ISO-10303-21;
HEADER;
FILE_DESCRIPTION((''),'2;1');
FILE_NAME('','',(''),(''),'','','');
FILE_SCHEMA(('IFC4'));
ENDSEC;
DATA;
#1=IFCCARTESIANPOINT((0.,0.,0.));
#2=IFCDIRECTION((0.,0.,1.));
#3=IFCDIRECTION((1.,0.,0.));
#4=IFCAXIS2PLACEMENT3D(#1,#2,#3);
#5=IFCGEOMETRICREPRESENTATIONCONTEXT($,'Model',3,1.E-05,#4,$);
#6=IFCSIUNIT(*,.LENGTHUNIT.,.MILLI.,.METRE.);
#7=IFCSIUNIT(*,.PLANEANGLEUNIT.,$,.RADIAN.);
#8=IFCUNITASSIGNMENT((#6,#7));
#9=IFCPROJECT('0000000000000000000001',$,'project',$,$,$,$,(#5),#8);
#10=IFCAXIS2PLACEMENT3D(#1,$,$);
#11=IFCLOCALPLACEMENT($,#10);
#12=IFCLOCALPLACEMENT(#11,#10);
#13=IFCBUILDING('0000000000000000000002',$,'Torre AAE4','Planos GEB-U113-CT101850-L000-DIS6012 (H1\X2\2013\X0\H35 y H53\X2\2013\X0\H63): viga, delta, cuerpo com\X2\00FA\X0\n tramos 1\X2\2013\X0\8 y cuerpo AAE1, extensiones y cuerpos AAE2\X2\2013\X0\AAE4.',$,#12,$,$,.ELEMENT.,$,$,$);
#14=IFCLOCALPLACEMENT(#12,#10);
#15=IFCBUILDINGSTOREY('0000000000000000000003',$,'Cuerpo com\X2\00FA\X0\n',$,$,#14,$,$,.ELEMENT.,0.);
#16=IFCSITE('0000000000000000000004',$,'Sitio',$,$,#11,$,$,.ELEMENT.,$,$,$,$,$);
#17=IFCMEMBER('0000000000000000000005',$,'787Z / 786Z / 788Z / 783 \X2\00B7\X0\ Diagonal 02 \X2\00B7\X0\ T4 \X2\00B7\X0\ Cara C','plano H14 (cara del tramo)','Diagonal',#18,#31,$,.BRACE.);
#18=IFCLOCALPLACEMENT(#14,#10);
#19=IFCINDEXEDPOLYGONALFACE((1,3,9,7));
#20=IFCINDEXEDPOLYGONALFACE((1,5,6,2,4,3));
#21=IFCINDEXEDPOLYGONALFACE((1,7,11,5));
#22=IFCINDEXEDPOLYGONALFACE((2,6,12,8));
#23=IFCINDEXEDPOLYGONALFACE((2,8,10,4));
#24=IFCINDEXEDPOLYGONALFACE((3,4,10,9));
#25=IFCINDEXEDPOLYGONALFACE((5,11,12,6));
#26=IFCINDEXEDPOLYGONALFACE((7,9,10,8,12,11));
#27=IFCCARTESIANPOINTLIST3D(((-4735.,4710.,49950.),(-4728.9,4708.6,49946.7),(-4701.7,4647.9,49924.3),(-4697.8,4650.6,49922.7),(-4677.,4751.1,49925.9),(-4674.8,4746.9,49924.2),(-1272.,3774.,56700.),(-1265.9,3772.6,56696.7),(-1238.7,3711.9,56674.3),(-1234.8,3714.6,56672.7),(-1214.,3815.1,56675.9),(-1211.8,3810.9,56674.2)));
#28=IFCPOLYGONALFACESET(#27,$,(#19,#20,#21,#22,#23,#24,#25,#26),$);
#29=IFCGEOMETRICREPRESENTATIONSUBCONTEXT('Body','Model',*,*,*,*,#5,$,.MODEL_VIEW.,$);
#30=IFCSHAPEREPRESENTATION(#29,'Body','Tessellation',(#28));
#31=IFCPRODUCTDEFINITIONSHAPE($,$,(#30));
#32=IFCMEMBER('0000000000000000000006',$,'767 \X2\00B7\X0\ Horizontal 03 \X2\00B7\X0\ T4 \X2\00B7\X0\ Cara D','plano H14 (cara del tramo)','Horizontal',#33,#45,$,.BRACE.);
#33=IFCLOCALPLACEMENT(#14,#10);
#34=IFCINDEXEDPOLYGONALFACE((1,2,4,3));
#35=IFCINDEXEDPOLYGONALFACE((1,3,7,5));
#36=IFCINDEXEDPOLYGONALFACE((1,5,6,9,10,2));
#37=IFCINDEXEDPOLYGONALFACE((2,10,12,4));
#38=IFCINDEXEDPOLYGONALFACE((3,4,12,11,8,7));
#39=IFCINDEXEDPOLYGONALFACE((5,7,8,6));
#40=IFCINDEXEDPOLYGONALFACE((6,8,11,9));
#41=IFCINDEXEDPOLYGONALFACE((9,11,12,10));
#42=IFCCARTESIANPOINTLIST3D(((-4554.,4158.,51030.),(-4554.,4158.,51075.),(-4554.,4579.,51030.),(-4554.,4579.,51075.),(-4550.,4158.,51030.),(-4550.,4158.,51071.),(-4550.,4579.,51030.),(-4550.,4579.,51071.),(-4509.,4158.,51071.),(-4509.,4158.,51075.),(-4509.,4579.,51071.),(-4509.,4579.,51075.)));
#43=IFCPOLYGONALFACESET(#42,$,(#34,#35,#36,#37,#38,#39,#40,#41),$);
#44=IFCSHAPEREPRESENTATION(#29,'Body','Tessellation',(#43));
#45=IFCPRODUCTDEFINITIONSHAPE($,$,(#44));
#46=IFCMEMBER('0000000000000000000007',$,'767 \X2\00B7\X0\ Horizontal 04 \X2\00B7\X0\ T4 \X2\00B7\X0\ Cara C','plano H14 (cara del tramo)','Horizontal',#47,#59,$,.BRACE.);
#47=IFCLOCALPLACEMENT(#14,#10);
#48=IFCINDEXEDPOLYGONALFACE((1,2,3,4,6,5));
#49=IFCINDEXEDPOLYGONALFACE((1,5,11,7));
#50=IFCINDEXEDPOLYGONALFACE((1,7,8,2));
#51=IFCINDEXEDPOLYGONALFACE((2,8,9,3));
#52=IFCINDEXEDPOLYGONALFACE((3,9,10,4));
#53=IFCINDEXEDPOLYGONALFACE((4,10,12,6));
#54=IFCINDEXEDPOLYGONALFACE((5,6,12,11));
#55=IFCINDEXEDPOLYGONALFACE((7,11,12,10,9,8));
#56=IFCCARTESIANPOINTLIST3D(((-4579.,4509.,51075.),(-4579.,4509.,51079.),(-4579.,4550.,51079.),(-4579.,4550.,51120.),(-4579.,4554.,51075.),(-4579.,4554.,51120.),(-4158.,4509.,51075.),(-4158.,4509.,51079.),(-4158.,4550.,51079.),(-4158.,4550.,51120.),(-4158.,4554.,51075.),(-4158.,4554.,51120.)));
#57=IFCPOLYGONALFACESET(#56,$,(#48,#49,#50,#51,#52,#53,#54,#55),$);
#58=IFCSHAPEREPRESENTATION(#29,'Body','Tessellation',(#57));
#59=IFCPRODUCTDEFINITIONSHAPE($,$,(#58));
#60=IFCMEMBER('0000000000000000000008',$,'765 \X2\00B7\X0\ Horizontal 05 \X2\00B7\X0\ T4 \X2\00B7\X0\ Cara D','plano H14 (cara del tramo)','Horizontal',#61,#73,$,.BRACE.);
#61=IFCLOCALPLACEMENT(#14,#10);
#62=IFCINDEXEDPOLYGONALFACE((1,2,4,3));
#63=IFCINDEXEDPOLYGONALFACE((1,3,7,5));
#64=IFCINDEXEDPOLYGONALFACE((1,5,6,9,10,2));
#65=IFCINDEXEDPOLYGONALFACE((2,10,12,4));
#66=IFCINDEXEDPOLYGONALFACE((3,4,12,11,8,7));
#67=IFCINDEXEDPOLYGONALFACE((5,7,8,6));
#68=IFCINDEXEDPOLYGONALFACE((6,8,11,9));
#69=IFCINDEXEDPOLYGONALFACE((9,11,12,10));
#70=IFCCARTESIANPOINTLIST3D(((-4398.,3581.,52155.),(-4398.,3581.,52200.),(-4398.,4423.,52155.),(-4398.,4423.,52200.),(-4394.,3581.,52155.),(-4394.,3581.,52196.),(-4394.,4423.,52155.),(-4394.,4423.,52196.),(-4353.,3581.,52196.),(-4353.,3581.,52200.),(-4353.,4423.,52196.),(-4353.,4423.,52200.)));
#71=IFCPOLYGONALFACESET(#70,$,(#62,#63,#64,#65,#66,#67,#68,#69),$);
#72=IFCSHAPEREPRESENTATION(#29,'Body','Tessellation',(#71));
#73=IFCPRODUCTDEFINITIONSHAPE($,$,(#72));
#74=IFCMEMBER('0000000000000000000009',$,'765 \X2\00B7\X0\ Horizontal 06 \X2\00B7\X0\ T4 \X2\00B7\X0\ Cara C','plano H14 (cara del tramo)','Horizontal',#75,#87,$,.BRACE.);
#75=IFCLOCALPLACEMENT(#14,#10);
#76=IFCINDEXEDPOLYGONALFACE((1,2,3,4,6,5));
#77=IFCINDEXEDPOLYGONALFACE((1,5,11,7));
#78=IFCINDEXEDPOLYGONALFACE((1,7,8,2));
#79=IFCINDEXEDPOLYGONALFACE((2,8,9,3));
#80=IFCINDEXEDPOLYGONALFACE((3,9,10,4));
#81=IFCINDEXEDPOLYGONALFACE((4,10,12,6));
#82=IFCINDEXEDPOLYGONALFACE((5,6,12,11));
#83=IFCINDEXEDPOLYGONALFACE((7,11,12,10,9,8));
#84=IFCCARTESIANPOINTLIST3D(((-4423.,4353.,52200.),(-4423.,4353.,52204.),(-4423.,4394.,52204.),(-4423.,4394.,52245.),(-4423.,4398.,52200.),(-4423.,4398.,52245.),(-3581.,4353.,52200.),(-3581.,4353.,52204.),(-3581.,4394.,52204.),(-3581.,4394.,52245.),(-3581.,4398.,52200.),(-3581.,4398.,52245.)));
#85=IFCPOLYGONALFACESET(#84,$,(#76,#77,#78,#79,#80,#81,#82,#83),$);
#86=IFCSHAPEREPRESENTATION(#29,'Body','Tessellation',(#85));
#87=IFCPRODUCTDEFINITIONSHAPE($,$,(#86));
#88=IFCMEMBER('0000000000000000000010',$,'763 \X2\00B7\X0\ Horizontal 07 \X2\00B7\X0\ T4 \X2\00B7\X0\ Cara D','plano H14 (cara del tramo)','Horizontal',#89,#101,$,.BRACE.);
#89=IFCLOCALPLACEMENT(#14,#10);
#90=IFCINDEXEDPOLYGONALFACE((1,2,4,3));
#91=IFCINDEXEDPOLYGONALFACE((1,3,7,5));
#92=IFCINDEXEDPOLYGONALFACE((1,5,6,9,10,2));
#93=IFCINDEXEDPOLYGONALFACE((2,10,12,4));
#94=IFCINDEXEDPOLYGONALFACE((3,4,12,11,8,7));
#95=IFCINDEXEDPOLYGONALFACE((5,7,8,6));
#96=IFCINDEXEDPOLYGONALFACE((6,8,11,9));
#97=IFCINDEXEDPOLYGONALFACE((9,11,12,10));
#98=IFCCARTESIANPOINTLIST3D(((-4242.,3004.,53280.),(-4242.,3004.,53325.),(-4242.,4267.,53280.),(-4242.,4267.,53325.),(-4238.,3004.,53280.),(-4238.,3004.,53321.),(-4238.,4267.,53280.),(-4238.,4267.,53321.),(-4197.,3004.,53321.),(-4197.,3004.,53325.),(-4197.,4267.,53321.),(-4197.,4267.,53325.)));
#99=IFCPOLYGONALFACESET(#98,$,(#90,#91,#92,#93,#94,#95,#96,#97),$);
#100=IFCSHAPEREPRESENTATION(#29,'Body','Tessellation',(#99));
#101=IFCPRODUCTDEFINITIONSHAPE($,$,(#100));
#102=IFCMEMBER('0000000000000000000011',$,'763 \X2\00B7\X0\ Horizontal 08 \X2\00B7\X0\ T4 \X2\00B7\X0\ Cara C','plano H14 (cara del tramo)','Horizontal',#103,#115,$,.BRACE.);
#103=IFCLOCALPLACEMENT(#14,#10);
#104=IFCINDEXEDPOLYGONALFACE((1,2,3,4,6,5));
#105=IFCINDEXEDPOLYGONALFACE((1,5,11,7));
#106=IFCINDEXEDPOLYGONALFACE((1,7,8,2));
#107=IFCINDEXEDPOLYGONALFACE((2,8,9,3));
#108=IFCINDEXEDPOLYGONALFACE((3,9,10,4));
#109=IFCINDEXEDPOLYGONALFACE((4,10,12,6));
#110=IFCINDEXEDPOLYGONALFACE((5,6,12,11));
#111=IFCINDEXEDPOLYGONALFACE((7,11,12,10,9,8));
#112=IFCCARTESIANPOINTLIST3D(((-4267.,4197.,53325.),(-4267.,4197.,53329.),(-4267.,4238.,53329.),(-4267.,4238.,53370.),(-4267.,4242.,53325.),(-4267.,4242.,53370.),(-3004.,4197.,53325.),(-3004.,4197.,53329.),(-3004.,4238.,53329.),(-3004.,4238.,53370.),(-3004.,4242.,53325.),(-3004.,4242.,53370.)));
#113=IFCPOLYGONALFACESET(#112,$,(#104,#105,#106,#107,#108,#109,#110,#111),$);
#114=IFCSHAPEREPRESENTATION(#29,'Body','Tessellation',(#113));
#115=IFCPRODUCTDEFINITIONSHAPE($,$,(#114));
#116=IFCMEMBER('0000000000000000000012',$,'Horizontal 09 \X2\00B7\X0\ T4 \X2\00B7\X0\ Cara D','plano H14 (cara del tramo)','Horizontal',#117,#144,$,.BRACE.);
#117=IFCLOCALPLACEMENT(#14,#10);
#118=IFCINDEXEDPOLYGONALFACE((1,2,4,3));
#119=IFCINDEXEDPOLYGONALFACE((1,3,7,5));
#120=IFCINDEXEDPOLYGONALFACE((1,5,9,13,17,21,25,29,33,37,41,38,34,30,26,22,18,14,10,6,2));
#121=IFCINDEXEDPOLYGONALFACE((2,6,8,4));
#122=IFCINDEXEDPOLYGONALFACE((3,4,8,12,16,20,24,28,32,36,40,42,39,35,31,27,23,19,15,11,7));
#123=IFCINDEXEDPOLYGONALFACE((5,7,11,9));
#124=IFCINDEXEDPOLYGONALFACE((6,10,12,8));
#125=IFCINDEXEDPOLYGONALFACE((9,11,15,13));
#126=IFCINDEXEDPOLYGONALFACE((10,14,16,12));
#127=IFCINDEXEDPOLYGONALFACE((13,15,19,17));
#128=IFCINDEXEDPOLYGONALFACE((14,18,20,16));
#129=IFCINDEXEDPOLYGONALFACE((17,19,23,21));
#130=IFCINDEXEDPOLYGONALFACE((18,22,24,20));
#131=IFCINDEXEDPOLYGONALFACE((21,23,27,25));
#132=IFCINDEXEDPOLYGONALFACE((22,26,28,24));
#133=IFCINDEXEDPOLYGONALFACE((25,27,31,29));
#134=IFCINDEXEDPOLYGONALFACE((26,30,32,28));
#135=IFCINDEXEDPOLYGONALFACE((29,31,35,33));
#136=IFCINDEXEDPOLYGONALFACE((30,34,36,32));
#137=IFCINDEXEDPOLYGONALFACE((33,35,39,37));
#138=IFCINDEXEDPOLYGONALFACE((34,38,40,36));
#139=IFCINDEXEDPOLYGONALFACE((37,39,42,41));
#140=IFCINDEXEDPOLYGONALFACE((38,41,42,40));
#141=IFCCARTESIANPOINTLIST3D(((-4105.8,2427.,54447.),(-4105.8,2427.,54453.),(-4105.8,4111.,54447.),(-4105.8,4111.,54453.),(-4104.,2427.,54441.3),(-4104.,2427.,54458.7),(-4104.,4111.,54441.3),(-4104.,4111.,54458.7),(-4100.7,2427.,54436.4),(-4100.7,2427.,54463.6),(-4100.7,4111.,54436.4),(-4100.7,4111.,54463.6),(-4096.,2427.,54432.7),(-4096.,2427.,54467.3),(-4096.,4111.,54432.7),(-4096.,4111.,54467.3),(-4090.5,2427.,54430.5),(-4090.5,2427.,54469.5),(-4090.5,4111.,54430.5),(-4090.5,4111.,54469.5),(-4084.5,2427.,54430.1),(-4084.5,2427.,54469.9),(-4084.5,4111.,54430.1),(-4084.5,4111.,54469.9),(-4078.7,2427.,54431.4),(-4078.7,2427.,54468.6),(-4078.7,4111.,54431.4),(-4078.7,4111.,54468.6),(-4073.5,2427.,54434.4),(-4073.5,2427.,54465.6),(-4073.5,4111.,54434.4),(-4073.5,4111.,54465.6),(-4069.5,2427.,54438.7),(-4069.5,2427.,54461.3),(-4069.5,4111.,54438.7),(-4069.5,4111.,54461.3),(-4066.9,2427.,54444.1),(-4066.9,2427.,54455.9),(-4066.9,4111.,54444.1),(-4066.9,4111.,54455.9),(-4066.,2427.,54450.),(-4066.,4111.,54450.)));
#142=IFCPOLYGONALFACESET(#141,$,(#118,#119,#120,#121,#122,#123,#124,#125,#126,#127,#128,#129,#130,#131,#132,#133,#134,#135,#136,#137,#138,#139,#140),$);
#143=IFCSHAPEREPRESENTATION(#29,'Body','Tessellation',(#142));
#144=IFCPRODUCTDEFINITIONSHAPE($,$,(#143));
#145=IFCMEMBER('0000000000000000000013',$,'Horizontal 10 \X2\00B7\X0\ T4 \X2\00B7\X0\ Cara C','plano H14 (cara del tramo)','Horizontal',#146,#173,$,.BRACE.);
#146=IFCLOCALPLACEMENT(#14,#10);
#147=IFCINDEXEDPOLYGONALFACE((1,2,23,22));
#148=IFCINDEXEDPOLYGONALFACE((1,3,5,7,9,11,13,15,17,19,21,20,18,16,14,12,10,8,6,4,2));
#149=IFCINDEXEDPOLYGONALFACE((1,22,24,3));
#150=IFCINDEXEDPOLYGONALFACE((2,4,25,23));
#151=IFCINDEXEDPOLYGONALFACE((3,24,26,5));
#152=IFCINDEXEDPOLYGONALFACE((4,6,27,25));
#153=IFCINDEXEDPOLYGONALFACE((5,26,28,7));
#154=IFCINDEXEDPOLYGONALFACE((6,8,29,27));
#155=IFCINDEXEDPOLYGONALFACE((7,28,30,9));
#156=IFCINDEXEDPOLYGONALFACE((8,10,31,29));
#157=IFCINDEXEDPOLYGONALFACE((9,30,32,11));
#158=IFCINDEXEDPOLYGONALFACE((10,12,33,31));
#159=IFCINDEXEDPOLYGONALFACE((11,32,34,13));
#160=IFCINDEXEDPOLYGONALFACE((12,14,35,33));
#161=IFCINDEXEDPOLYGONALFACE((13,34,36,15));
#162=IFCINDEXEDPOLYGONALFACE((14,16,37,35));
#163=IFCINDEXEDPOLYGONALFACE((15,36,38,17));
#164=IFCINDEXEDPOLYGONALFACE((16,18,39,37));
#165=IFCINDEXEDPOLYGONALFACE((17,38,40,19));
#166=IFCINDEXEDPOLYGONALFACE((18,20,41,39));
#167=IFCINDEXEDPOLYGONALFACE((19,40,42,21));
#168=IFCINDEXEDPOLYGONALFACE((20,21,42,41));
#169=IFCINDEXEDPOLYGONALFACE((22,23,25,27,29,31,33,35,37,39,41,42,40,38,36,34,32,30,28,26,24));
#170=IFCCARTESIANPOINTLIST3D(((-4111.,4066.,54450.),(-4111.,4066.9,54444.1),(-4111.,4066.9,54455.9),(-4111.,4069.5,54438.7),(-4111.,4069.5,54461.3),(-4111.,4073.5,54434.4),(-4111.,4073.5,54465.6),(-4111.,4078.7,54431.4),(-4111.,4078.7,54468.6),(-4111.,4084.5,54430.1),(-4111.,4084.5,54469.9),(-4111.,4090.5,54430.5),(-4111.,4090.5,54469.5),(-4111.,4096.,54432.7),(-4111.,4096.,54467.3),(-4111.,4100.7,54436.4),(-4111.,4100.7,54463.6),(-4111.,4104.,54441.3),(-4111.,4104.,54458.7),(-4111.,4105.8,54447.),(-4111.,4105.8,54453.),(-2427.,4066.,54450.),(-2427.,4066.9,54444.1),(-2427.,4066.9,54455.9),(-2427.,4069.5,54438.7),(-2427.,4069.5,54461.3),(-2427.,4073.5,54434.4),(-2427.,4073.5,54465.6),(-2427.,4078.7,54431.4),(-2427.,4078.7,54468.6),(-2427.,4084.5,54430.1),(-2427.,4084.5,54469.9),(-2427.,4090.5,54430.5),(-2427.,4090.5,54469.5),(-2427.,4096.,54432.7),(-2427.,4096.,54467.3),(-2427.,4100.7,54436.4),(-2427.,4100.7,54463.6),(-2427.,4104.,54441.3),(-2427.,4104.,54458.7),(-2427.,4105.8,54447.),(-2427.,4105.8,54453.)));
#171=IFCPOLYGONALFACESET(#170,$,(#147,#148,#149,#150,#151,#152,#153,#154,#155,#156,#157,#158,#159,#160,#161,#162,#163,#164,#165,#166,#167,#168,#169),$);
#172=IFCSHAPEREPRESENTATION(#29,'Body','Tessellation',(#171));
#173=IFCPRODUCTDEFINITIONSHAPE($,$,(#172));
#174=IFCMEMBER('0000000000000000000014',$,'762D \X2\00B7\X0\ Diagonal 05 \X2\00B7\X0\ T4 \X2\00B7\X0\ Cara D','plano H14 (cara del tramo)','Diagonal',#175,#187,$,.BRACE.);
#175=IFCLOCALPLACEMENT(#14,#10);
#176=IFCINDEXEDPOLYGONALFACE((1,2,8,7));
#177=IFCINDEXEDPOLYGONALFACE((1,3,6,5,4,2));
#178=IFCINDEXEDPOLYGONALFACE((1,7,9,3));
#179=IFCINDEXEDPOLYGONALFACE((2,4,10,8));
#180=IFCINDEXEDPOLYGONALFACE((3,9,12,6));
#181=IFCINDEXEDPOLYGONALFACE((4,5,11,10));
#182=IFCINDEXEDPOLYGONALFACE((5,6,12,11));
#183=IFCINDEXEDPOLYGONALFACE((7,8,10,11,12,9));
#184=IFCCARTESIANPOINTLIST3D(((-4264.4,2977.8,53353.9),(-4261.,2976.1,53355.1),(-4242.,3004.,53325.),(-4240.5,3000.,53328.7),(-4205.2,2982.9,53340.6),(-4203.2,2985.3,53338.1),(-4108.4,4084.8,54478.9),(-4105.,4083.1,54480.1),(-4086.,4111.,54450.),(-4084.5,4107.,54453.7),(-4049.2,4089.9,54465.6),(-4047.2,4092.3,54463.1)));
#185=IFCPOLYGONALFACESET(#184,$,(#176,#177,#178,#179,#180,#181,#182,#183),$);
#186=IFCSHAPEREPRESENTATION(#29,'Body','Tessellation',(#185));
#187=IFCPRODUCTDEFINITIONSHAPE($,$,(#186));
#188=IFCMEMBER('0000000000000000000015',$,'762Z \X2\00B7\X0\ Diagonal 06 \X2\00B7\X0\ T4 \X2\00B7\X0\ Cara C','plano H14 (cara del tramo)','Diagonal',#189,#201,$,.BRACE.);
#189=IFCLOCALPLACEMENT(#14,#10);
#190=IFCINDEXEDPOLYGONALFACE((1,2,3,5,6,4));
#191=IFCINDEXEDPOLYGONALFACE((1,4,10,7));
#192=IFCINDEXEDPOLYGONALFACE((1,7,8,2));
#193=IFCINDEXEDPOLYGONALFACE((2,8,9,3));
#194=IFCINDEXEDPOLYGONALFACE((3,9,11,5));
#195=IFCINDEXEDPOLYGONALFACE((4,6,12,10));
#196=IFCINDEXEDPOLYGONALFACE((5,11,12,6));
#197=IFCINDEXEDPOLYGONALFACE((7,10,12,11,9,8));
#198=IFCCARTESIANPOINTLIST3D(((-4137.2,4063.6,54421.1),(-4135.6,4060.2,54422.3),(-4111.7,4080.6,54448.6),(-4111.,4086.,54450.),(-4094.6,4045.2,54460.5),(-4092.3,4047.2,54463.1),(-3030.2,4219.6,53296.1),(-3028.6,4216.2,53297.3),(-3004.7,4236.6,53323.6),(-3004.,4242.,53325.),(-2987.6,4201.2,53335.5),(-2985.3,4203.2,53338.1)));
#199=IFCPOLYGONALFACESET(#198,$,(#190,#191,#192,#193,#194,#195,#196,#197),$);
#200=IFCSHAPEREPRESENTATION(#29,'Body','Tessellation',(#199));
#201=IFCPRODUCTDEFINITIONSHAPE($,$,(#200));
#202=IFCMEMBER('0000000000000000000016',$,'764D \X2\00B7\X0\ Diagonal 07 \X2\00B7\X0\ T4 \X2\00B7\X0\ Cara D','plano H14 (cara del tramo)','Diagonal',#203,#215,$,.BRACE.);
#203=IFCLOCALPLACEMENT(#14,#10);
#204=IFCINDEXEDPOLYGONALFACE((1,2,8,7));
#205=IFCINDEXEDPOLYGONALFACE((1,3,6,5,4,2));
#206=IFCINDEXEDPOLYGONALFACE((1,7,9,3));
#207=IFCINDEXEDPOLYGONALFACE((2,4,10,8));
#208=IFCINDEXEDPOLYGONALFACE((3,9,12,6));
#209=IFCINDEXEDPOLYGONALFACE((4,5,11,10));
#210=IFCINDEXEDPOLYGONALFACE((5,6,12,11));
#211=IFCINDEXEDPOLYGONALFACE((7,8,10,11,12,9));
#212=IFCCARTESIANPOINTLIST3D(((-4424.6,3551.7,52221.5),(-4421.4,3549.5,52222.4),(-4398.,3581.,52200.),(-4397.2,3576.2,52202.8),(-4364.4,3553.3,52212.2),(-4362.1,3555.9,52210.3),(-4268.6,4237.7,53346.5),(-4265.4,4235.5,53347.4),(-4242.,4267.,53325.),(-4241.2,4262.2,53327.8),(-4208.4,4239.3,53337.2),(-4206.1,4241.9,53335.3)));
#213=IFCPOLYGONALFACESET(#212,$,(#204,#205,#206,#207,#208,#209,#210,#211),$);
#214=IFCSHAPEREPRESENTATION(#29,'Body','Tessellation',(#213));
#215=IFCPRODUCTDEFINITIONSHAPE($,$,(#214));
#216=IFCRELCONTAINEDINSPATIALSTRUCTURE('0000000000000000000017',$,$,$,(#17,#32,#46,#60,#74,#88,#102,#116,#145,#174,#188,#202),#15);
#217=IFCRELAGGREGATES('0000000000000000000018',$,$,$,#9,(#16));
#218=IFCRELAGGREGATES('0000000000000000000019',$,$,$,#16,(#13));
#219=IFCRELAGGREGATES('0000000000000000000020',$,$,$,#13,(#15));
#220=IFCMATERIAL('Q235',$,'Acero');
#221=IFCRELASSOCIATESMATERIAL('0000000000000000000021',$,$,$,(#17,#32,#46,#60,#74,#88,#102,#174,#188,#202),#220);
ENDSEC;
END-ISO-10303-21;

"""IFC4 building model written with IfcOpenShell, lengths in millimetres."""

from ifc_helpers import new_model, si_unit, frame, frame_2d, origin, origin_with_axes, place, context, subcontext, project, spatial, circle, l_section, extrude, material, element, save


model = new_model("IFC4")

# Units and contexts
model_context = context("Model", 3, precision=1e-05, world=origin_with_axes())
body_context = subcontext(model_context, "Body", "Model", "MODEL_VIEW")
ifc_project = project(units=[si_unit("LENGTHUNIT", "METRE", prefix="MILLI"), si_unit("PLANEANGLEUNIT", "RADIAN")], contexts=[model_context])

# Site, building, storey
site_placement = place(None, origin())
site = spatial("IfcSite", under=ifc_project, at=site_placement, Name="Sitio", CompositionType="ELEMENT")
building_placement = place(site_placement, origin())
building = spatial("IfcBuilding", under=site, at=building_placement, Name="Torre AAE4", Description="Planos GEB-U113-CT101850-L000-DIS6012 (H1–H35 y H53–H63): viga, delta, cuerpo común tramos 1–8 y cuerpo AAE1, extensiones y cuerpos AAE2–AAE4.", CompositionType="ELEMENT")
storey_placement = place(building_placement, origin())
storey = spatial("IfcBuildingStorey", under=building, at=storey_placement, Name="Cuerpo común", CompositionType="ELEMENT", Elevation=0.0)

# Members
ifc_material_1 = material(Name="Q235", Category="Acero")
member_1_placement = place(storey_placement, frame((-4735.0, 4710.0, 49950.0), z_axis=(0.453034, -0.122449, 0.883044), x_axis=(0.444053, -0.827907, -0.342619)))
element("IfcMember", 1, at=member_1_placement, inside=storey, material=ifc_material_1, Name="787Z / 786Z / 788Z / 783 · Diagonal 02 · T4 · Cara C", Description="plano H14 (cara del tramo)", ObjectType="Diagonal", PredefinedType="BRACE", context=body_context, shape_type="SweptSolid", body=[
    extrude(l_section(Depth=75.0, Width=75.0, Thickness=5.0, at=frame_2d((37.5, 37.5))), None, (0.0, 0.0, 1.0), 7644.0),
])
for number, where, z_axis, x_axis, name in (
    (2, (-4554.0, 4158.0, 51075.0), (0.0, 1.0, 0.0), (1.0, 0.0, 0.0), "767 · Horizontal 03 · T4 · Cara D"),
    (3, (-4158.0, 4554.0, 51075.0), (-1.0, 0.0, 0.0), (0.0, -1.0, 0.0), "767 · Horizontal 04 · T4 · Cara C"),
):
    element("IfcMember", number, at=place(storey_placement, frame(where, z_axis=z_axis, x_axis=x_axis)), inside=storey, material=ifc_material_1, Name=name, Description="plano H14 (cara del tramo)", ObjectType="Horizontal", PredefinedType="BRACE", context=body_context, shape_type="SweptSolid", body=[
        extrude(l_section(Depth=45.0, Width=45.0, Thickness=4.0, at=frame_2d((22.5, 22.5))), None, (0.0, 0.0, 1.0), 421.0),
    ])
for number, where, z_axis, x_axis, name in (
    (4, (-4398.0, 3581.0, 52200.0), (0.0, 1.0, 0.0), (1.0, 0.0, 0.0), "765 · Horizontal 05 · T4 · Cara D"),
    (5, (-3581.0, 4398.0, 52200.0), (-1.0, 0.0, 0.0), (0.0, -1.0, 0.0), "765 · Horizontal 06 · T4 · Cara C"),
):
    element("IfcMember", number, at=place(storey_placement, frame(where, z_axis=z_axis, x_axis=x_axis)), inside=storey, material=ifc_material_1, Name=name, Description="plano H14 (cara del tramo)", ObjectType="Horizontal", PredefinedType="BRACE", context=body_context, shape_type="SweptSolid", body=[
        extrude(l_section(Depth=45.0, Width=45.0, Thickness=4.0, at=frame_2d((22.5, 22.5))), None, (0.0, 0.0, 1.0), 842.0),
    ])
for number, where, z_axis, x_axis, name in (
    (6, (-4242.0, 3004.0, 53325.0), (0.0, 1.0, 0.0), (1.0, 0.0, 0.0), "763 · Horizontal 07 · T4 · Cara D"),
    (7, (-3004.0, 4242.0, 53325.0), (-1.0, 0.0, 0.0), (0.0, -1.0, 0.0), "763 · Horizontal 08 · T4 · Cara C"),
):
    element("IfcMember", number, at=place(storey_placement, frame(where, z_axis=z_axis, x_axis=x_axis)), inside=storey, material=ifc_material_1, Name=name, Description="plano H14 (cara del tramo)", ObjectType="Horizontal", PredefinedType="BRACE", context=body_context, shape_type="SweptSolid", body=[
        extrude(l_section(Depth=45.0, Width=45.0, Thickness=4.0, at=frame_2d((22.5, 22.5))), None, (0.0, 0.0, 1.0), 1263.0),
    ])
for number, where, z_axis, x_axis, name in (
    (8, (-4086.0, 2427.0, 54450.0), (0.0, 1.0, 0.0), (1.0, 0.0, 0.0), "Horizontal 09 · T4 · Cara D"),
    (9, (-2427.0, 4086.0, 54450.0), (-1.0, 0.0, 0.0), (0.0, -1.0, 0.0), "Horizontal 10 · T4 · Cara C"),
):
    element("IfcMember", number, at=place(storey_placement, frame(where, z_axis=z_axis, x_axis=x_axis)), inside=storey, Name=name, Description="plano H14 (cara del tramo)", ObjectType="Horizontal", PredefinedType="BRACE", context=body_context, shape_type="SweptSolid", body=[
        extrude(circle(Radius=20.0), None, (0.0, 0.0, 1.0), 1684.0),
    ])
for number, where, z_axis, x_axis, name in (
    (10, (-4086.0, 4111.0, 54450.0), (-0.09836, -0.69798, -0.70933), (0.861689, -0.416299, 0.290151), "762D · Diagonal 05 · T4 · Cara D"),
    (11, (-4111.0, 4086.0, 54450.0), (0.69798, 0.09836, -0.70933), (0.416299, -0.861689, 0.290151), "762Z · Diagonal 06 · T4 · Cara C"),
):
    element("IfcMember", number, at=place(storey_placement, frame(where, z_axis=z_axis, x_axis=x_axis)), inside=storey, material=ifc_material_1, Name=name, Description="plano H14 (cara del tramo)", ObjectType="Diagonal", PredefinedType="BRACE", context=body_context, shape_type="SweptSolid", body=[
        extrude(l_section(Depth=45.0, Width=45.0, Thickness=4.0, at=frame_2d((22.5, 22.5))), None, (0.0, 0.0, 1.0), 1586.0),
    ])
for number, where, z_axis, x_axis, name in (
    (12, (-4242.0, 4267.0, 53325.0), (-0.117571, -0.51701, -0.847867), (0.798444, -0.556878, 0.228854), "764D · Diagonal 07 · T4 · Cara D"),
):
    element("IfcMember", number, at=place(storey_placement, frame(where, z_axis=z_axis, x_axis=x_axis)), inside=storey, material=ifc_material_1, Name=name, Description="plano H14 (cara del tramo)", ObjectType="Diagonal", PredefinedType="BRACE", context=body_context, shape_type="SweptSolid", body=[
        extrude(l_section(Depth=45.0, Width=45.0, Thickness=4.0, at=frame_2d((22.5, 22.5))), None, (0.0, 0.0, 1.0), 1326.9),
    ])

save(model, "model.ifc")
